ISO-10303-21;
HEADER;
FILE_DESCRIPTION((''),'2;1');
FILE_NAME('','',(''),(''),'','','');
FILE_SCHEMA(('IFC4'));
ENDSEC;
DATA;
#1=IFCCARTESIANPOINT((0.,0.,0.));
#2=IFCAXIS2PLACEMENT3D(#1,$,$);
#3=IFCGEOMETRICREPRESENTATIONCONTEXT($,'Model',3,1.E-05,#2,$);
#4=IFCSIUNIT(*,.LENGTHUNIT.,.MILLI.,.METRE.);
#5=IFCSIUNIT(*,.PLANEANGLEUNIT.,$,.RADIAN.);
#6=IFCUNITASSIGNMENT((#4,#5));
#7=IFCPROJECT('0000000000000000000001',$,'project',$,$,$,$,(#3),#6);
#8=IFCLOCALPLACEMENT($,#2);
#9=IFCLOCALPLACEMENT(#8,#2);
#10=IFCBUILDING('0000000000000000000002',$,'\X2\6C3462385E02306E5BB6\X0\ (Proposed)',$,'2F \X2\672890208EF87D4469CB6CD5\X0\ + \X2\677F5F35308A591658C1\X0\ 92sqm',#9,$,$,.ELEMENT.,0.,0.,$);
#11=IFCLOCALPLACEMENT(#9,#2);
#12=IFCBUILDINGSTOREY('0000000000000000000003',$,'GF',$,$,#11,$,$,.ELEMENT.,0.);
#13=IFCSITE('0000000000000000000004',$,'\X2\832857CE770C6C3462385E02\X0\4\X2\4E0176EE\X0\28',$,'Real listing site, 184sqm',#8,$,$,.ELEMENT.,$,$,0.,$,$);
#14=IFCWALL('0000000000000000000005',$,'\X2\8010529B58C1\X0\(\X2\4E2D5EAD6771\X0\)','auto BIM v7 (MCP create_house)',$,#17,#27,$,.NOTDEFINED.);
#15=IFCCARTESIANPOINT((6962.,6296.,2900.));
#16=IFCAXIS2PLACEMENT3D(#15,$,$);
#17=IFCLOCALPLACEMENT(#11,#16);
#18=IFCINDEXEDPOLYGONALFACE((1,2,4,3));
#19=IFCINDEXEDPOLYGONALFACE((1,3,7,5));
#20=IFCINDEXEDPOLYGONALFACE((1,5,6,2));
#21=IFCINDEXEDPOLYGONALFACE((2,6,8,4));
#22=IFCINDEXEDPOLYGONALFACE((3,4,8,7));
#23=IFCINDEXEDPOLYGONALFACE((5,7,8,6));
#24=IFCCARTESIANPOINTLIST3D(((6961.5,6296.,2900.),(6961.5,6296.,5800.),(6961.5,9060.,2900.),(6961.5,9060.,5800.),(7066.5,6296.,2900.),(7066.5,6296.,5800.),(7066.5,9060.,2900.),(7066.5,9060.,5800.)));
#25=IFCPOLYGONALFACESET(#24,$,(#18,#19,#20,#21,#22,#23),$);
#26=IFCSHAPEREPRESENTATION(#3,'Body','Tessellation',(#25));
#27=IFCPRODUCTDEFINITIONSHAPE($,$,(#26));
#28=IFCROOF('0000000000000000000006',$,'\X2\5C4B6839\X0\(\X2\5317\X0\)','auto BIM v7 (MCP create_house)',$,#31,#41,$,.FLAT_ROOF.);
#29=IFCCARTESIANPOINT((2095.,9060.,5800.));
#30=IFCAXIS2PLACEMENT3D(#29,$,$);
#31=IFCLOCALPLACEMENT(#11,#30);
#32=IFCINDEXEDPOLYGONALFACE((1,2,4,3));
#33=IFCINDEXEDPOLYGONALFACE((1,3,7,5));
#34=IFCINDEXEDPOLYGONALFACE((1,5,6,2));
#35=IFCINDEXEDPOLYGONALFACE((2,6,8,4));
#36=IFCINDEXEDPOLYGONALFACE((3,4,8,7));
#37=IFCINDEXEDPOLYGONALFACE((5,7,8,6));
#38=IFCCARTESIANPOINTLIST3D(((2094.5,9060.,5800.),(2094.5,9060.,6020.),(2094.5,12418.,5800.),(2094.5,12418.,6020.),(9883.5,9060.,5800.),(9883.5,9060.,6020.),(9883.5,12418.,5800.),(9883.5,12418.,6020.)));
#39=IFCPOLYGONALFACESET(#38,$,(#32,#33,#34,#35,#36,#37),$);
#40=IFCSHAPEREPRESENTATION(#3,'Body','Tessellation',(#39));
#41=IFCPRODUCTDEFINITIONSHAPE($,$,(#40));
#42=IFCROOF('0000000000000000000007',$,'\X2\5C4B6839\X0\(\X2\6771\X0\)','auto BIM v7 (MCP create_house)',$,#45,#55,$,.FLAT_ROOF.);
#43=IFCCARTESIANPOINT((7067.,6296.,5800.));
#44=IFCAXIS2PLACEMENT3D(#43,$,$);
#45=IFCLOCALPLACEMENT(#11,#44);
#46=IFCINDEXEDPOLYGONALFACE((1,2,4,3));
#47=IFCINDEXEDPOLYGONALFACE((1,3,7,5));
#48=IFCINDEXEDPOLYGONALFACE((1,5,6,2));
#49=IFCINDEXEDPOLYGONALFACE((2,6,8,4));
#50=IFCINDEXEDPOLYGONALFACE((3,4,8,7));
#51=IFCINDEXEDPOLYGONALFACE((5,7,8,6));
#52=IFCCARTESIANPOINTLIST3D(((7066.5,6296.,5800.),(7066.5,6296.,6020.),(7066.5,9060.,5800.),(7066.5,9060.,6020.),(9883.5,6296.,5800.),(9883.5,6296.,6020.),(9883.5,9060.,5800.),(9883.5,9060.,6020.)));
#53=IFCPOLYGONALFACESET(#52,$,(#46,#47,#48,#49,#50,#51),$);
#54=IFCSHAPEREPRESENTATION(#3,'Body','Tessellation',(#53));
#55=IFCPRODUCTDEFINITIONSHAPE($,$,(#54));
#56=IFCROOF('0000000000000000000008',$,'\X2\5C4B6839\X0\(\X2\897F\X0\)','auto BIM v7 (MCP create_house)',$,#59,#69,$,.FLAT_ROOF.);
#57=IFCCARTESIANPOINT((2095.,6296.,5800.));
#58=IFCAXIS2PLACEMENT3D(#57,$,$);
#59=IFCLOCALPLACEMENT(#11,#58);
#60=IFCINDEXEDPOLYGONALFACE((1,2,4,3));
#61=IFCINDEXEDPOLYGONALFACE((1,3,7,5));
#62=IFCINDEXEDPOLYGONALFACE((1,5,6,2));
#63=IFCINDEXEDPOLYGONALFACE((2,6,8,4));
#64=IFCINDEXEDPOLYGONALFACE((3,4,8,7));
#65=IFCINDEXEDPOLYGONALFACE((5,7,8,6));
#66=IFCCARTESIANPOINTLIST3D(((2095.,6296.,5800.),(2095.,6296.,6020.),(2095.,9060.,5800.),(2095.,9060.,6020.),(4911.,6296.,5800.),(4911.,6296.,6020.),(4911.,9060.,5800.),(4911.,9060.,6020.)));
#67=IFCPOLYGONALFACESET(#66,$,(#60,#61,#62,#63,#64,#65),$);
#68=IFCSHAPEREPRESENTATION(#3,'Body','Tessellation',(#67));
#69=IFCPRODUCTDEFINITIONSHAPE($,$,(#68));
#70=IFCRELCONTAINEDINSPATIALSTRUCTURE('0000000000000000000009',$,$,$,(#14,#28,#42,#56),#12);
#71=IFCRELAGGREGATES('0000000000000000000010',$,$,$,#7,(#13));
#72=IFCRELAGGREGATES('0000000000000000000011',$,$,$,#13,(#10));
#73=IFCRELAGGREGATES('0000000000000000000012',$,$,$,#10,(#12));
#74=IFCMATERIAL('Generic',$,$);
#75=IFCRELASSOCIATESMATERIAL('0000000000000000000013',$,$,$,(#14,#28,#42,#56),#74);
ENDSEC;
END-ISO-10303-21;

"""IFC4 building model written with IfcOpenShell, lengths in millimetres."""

from ifc_helpers import new_model, si_unit, frame, frame_2d, origin, place, context, project, spatial, rectangle, extrude, material, element, save


model = new_model("IFC4")

# Units and contexts
model_context = context("Model", 3, precision=1e-05, world=origin())
ifc_project = project(units=[si_unit("LENGTHUNIT", "METRE", prefix="MILLI"), si_unit("PLANEANGLEUNIT", "RADIAN")], contexts=[model_context])

# Site, building, storey
site_placement = place(None, origin())
site = spatial("IfcSite", under=ifc_project, at=site_placement, Name="茨城県水戸市4丁目28", ObjectType="Real listing site, 184sqm", CompositionType="ELEMENT", RefElevation=0.0)
building_placement = place(site_placement, origin())
building = spatial("IfcBuilding", under=site, at=building_placement, Name="水戸市の家 (Proposed)", ObjectType="2F 木造軸組構法 + 板張り外壁 92sqm", CompositionType="ELEMENT", ElevationOfRefHeight=0.0, ElevationOfTerrain=0.0)
storey_placement = place(building_placement, origin())
storey = spatial("IfcBuildingStorey", under=building, at=storey_placement, Name="GF", CompositionType="ELEMENT", Elevation=0.0)

# Shared definitions
ifc_material = material(Name="Generic")

# Wall
wall_1_placement = place(storey_placement, frame((6962.0, 6296.0, 2900.0)))
element("IfcWall", 1, at=wall_1_placement, inside=storey, material=ifc_material, Name="耐力壁(中庭東)", Description="auto BIM v7 (MCP create_house)", PredefinedType="NOTDEFINED", context=model_context, shape_type="SweptSolid", body=[
    extrude(rectangle(XDim=105.0, YDim=2764.0, at=frame_2d((52.0, 1382.0))), frame((6962.0, 6296.0, 2900.0)), (0.0, 0.0, 1.0), 2900.0),
])

# Roofs
roof_1_placement = place(storey_placement, frame((2095.0, 9060.0, 5800.0)))
element("IfcRoof", 2, at=roof_1_placement, inside=storey, material=ifc_material, Name="屋根(北)", Description="auto BIM v7 (MCP create_house)", PredefinedType="FLAT_ROOF", context=model_context, shape_type="SweptSolid", body=[
    extrude(rectangle(XDim=7789.0, YDim=3358.0, at=frame_2d((3894.0, 1679.0))), frame((2095.0, 9060.0, 5800.0)), (0.0, 0.0, 1.0), 220.0),
])
roof_2_placement = place(storey_placement, frame((7067.0, 6296.0, 5800.0)))
element("IfcRoof", 3, at=roof_2_placement, inside=storey, material=ifc_material, Name="屋根(東)", Description="auto BIM v7 (MCP create_house)", PredefinedType="FLAT_ROOF", context=model_context, shape_type="SweptSolid", body=[
    extrude(rectangle(XDim=2817.0, YDim=2764.0, at=frame_2d((1408.0, 1382.0))), frame((7067.0, 6296.0, 5800.0)), (0.0, 0.0, 1.0), 220.0),
])
roof_3_placement = place(storey_placement, frame((2095.0, 6296.0, 5800.0)))
element("IfcRoof", 4, at=roof_3_placement, inside=storey, material=ifc_material, Name="屋根(西)", Description="auto BIM v7 (MCP create_house)", PredefinedType="FLAT_ROOF", context=model_context, shape_type="SweptSolid", body=[
    extrude(rectangle(XDim=2816.0, YDim=2764.0, at=frame_2d((1408.0, 1382.0))), frame((2095.0, 6296.0, 5800.0)), (0.0, 0.0, 1.0), 220.0),
])

save(model, "model.ifc")
